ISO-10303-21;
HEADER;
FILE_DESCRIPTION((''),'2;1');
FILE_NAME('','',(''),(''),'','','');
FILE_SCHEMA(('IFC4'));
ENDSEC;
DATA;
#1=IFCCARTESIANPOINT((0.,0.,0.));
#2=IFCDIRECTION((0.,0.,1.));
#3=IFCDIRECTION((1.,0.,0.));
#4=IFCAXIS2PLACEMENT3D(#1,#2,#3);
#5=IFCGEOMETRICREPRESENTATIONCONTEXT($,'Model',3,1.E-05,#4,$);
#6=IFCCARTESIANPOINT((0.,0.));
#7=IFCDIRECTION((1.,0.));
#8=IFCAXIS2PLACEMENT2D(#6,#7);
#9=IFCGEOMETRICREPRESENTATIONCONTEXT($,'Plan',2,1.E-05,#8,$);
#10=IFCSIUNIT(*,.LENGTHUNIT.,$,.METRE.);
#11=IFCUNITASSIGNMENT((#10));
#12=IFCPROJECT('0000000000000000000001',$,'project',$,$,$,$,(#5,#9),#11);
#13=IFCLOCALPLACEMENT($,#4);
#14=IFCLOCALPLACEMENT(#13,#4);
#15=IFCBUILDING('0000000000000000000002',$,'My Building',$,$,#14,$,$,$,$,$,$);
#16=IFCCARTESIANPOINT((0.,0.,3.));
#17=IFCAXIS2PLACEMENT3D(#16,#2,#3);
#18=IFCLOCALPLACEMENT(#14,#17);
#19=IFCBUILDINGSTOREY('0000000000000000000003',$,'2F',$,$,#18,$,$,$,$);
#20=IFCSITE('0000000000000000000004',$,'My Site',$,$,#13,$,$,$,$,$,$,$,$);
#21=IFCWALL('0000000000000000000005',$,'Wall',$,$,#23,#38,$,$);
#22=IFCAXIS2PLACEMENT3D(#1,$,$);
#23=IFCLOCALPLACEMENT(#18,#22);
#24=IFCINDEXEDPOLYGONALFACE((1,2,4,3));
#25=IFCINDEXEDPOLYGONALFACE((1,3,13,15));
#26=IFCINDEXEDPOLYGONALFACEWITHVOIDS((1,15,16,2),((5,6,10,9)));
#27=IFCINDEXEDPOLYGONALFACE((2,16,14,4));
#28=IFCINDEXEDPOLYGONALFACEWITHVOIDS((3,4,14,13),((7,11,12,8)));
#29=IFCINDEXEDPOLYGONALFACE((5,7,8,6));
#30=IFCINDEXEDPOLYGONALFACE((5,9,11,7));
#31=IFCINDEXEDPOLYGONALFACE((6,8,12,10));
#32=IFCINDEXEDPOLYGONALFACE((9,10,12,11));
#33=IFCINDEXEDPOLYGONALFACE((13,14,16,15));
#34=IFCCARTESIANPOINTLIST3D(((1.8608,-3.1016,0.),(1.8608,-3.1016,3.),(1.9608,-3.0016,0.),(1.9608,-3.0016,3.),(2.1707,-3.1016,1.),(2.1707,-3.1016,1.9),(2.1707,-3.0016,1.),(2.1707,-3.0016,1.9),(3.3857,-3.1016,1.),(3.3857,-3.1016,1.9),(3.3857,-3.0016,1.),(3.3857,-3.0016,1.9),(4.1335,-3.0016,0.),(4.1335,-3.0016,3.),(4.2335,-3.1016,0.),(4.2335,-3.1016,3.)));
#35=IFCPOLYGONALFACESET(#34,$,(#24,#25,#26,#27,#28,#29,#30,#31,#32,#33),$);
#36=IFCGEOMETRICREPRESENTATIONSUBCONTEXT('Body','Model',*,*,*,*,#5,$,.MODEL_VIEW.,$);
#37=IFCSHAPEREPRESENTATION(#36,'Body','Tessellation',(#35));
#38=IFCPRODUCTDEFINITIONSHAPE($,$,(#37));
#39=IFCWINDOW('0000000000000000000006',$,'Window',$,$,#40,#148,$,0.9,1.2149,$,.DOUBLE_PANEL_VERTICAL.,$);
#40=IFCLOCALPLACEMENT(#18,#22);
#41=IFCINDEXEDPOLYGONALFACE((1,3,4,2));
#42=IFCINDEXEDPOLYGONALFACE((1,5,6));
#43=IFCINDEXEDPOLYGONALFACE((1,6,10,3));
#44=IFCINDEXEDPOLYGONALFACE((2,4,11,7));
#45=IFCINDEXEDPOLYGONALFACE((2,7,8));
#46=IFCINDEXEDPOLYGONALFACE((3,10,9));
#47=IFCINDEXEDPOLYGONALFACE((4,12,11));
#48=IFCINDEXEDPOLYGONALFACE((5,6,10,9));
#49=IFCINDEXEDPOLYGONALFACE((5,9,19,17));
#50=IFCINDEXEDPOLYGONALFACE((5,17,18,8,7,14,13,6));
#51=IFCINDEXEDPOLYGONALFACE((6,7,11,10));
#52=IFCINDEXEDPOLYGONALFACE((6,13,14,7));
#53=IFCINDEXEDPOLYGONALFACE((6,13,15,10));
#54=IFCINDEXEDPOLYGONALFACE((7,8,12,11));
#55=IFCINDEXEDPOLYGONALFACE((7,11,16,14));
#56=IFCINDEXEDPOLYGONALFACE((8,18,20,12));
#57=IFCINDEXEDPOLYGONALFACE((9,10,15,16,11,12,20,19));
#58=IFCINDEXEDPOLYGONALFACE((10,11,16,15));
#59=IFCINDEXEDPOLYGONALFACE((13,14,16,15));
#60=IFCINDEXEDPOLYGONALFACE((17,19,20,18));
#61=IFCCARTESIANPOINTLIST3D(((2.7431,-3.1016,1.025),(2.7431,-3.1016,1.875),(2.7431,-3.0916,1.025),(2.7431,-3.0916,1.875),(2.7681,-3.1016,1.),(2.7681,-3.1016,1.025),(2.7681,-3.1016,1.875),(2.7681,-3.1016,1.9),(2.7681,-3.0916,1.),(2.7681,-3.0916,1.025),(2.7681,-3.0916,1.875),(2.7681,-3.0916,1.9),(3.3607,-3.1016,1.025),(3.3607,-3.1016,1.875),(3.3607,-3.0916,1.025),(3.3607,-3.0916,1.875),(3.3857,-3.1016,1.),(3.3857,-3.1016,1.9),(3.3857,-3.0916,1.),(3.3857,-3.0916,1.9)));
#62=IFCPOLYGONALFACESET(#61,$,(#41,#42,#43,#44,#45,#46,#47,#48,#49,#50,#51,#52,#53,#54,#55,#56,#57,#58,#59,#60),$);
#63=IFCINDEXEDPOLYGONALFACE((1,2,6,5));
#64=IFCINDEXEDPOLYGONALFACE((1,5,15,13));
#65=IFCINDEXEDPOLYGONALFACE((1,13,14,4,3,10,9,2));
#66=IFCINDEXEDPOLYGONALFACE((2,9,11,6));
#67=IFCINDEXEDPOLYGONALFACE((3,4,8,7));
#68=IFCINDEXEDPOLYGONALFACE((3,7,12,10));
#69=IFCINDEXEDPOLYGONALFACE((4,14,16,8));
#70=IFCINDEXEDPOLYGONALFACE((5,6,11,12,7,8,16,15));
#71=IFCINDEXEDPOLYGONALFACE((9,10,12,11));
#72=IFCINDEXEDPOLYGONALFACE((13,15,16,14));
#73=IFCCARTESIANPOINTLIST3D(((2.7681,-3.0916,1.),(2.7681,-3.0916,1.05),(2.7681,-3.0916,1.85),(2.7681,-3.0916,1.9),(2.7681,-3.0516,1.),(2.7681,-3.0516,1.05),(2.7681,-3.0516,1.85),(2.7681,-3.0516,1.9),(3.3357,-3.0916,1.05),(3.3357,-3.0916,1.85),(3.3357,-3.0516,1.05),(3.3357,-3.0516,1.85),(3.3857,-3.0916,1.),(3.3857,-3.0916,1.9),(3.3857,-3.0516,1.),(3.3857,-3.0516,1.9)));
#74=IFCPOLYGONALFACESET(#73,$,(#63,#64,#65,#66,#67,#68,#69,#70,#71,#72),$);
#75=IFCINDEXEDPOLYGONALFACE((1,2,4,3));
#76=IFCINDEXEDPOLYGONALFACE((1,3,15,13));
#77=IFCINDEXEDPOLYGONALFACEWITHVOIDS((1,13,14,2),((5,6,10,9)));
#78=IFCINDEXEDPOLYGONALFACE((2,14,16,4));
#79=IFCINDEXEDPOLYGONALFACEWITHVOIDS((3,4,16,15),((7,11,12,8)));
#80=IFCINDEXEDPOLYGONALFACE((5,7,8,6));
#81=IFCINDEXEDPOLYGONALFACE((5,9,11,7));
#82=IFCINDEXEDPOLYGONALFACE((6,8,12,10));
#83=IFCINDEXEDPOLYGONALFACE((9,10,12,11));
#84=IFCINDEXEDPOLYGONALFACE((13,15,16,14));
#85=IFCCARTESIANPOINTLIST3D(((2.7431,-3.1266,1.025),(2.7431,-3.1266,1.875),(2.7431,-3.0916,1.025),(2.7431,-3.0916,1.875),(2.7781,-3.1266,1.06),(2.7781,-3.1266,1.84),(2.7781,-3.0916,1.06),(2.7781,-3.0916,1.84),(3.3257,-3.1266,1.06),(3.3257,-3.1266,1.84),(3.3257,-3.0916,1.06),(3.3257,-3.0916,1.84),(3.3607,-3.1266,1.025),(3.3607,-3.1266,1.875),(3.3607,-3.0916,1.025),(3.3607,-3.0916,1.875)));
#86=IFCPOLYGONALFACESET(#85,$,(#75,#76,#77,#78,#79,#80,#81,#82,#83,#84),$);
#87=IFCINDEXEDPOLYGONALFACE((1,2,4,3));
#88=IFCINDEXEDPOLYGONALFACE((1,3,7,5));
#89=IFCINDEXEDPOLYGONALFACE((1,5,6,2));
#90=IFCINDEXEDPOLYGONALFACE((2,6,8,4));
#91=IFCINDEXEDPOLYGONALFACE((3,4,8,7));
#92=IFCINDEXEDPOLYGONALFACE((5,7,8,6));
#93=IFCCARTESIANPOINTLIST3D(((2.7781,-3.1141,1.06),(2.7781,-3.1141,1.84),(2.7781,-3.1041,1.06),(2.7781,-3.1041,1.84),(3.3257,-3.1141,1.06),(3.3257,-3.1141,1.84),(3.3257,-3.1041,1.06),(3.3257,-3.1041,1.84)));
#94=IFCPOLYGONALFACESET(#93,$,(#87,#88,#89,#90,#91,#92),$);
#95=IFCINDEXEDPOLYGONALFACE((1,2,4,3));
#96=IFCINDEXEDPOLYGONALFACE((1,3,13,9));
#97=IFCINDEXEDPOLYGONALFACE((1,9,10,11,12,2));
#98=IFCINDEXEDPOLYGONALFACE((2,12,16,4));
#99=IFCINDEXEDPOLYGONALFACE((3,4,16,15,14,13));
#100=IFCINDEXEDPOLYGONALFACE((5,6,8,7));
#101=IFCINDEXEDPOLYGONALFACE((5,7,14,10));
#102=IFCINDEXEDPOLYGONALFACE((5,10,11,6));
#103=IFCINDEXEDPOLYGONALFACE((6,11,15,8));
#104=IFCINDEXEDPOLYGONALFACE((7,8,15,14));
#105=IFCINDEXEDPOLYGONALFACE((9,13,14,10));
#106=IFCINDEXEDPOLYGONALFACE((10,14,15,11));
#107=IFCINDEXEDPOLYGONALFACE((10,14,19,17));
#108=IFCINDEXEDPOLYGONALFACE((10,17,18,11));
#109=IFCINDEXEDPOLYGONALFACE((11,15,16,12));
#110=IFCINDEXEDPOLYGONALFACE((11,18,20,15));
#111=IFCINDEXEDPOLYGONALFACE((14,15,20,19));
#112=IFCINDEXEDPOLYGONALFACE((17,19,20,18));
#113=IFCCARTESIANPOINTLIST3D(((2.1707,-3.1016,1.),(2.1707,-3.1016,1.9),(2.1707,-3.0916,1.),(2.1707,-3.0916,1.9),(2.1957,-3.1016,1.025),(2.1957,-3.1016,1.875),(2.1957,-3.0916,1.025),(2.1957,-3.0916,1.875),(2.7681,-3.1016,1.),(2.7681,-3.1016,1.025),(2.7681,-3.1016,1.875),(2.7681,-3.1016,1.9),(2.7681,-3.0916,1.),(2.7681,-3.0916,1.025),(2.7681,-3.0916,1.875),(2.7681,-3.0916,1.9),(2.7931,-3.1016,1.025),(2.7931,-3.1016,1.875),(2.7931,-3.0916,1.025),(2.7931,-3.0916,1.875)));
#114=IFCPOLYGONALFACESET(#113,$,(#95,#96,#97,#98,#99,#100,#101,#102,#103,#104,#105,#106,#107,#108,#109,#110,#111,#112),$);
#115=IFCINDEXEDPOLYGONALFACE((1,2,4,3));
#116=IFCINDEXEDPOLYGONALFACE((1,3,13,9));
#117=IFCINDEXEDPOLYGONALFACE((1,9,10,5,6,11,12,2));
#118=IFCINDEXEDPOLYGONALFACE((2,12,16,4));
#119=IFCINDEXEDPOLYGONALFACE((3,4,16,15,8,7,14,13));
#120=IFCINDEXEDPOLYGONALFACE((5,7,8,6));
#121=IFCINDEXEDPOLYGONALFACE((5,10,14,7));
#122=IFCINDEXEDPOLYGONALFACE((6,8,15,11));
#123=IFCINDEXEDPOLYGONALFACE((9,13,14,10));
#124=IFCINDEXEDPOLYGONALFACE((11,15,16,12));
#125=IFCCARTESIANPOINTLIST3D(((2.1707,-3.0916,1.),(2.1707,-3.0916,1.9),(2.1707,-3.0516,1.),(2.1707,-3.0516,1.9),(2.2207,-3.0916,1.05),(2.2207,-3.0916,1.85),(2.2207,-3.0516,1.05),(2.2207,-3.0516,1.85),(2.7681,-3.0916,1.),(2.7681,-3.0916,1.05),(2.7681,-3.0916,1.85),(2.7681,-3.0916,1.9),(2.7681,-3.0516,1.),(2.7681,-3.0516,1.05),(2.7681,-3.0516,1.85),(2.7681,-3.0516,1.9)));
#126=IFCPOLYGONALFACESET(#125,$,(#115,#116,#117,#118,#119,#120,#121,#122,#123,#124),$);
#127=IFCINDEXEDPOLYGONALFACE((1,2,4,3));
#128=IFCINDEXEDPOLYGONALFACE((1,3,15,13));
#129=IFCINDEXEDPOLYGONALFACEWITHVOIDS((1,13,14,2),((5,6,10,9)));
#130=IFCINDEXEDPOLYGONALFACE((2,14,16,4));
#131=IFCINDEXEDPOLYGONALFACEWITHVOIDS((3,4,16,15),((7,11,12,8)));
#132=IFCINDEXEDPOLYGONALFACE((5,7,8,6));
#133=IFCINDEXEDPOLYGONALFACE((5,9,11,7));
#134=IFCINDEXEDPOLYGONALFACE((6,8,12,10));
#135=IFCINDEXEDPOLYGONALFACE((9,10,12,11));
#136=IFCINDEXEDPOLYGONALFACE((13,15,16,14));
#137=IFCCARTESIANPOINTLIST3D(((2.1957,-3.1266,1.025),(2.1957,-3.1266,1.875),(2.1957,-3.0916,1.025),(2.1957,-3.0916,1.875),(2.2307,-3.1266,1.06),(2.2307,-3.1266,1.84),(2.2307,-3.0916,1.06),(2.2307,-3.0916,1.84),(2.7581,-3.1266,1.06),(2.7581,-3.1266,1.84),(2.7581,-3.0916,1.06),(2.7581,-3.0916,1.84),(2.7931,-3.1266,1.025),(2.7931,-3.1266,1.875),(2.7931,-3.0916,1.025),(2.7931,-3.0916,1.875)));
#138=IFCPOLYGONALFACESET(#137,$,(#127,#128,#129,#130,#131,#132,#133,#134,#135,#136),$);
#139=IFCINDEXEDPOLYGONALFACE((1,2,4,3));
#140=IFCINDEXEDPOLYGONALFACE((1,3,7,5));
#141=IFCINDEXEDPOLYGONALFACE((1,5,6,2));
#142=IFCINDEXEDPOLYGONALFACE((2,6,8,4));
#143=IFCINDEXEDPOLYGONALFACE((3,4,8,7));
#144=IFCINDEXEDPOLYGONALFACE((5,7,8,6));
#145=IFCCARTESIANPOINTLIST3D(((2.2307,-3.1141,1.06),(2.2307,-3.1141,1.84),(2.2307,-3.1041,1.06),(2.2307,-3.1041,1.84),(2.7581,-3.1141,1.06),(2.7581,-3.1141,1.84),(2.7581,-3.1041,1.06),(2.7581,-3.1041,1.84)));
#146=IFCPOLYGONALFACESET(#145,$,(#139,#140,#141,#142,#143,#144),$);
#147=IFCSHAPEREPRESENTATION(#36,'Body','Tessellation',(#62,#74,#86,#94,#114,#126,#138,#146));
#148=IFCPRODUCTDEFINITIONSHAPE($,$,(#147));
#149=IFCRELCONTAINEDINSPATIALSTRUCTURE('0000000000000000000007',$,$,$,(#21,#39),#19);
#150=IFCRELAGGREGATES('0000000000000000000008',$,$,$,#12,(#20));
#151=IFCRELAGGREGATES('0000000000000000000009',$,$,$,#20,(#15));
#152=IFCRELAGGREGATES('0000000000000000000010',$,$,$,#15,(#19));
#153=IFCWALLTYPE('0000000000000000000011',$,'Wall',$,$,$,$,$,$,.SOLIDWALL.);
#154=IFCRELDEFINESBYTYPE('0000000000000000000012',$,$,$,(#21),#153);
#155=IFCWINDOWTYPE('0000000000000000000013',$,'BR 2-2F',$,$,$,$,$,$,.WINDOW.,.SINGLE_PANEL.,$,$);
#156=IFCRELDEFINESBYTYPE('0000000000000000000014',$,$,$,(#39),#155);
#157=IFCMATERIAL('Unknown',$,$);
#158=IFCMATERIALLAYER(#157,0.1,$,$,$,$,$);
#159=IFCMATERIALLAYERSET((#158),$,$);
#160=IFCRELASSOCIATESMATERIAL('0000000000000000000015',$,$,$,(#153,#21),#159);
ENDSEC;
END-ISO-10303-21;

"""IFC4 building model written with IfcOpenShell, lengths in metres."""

from ifc_helpers import new_model, entity, si_unit, frame, origin_with_axes, origin_2d_with_axis, place, context, subcontext, project, spatial, line, indexed_curve, outline, extrude, shape, source, transform, mapped, material, layer, layer_set, layer_usage, type_object, type_shapes, element, fill, save


model = new_model("IFC4")

# Units and contexts
model_context = context("Model", 3, precision=1e-05, world=origin_with_axes())
plan_context = context("Plan", 2, precision=1e-05, world=origin_2d_with_axis())
body_context_1 = subcontext(model_context, "Body", "Model", "MODEL_VIEW")
body_context_2 = subcontext(plan_context, "Body", "Plan", "PLAN_VIEW")
ifc_project = project(units=[si_unit("LENGTHUNIT", "METRE")], contexts=[model_context, plan_context])

# Site, building, storey
site_placement = place(None, origin_with_axes())
site = spatial("IfcSite", under=ifc_project, at=site_placement, Name="My Site")
building_placement = place(site_placement, origin_with_axes())
building = spatial("IfcBuilding", under=site, at=building_placement, Name="My Building")
storey_placement = place(building_placement, frame((0.0, 0.0, 3.0), z_axis=(0.0, 0.0, 1.0), x_axis=(1.0, 0.0, 0.0)))
storey = spatial("IfcBuildingStorey", under=building, at=storey_placement, Name="2F")

# Shared definitions
ifc_material = material(Name="Unknown")

# Shared definitions
ifc_layer_1 = layer(ifc_material, 0.1)
ifc_layer_set_1 = layer_set([ifc_layer_1])
wall_type = type_object("IfcWallType", Name="Wall", PredefinedType="SOLIDWALL", material=ifc_layer_set_1)

# Wall, opening, window
ifc_layer_usage_1 = layer_usage(ifc_layer_set_1, "AXIS2", "POSITIVE", 0.0)
wall_1_placement = place(storey_placement, frame((1.8608, -3.1016, 0.0), z_axis=(0.0, 0.0, 1.0), x_axis=(1.0, 0.0, 0.0)))
wall_1 = element("IfcWall", 1, at=wall_1_placement, inside=storey, type_object=wall_type, material=ifc_layer_usage_1, Name="Wall", context=body_context_1, shape_type="SweptSolid", body=[
    extrude(outline(indexed_curve([(0.0, 0.0), (0.1, 0.1), (2.2727, 0.1), (2.3727, 0.0)], segments=[line(1, 2, 3, 4, 1)])), origin_with_axes(), (0.0, 0.0, 1.0), 3.0),
])
shared_shape_1 = source(origin_with_axes(), body_context_1, "Body", "SweptSolid", [
    extrude(outline(indexed_curve([(0.0, 0.0), (1.2149, 0.0), (1.2149, 0.9), (0.0, 0.9)], segments=[line(1, 2, 3, 4, 1)])), frame((0.0, -0.6, 0.0), z_axis=(0.0, -1.0, 0.0), x_axis=(1.0, 0.0, 0.0)), (0.0, 0.0, -1.0), 1.2),
])
opening_1_placement = place(wall_1_placement, frame((1.5248, 0.1, 1.0), z_axis=(0.0, 0.0, 1.0), x_axis=(-1.0, 0.000001, 0.0)))
opening_1 = element("IfcOpeningElement", 2, at=opening_1_placement, cuts=wall_1, PredefinedType="OPENING", context=body_context_1, shape_type="MappedRepresentation", body=[
    mapped(shared_shape_1, transform((0.0, 0.0, 0.0), x_axis=(1.0, 0.0, 0.0), y_axis=(0.0, 1.0, 0.0), z_axis=(0.0, 0.0, 1.0), scale=1.0)),
])
window_type = type_object("IfcWindowType", Name="BR 2-2F", PartitioningType="SINGLE_PANEL", PredefinedType="WINDOW")
shared_shape_2 = source(origin_with_axes(), body_context_1, "Body", "SweptSolid", [
    extrude(outline(indexed_curve([(0.0, 0.0), (0.6176, 0.0), (0.6176, 0.9), (0.0, 0.9)], segments=[line(1, 2, 3, 4, 1)]), holes=[indexed_curve([(0.025, 0.025), (0.6426, 0.025), (0.6426, 0.875), (0.025, 0.875)], segments=[line(1, 2, 3, 4, 1)])]), frame((0.0, 0.09, 0.0), z_axis=(0.0, -1.0, 0.0), x_axis=(1.0, 0.0, 0.0)), (0.0, 0.0, -1.0), 0.01),
    extrude(outline(indexed_curve([(0.6176, 0.0), (0.0, 0.0), (0.0, 0.9), (0.6176, 0.9), (0.6176, 0.85), (0.05, 0.85), (0.05, 0.05), (0.6176, 0.05)], segments=[line(1, 2, 3, 4, 5, 6, 7, 8, 1)])), frame((0.0, 0.05, 0.0), z_axis=(0.0, -1.0, 0.0), x_axis=(1.0, 0.0, 0.0)), (0.0, 0.0, -1.0), 0.04),
    extrude(outline(indexed_curve([(0.0, 0.0), (0.6176, 0.0), (0.6176, 0.85), (0.0, 0.85)], segments=[line(1, 2, 3, 4, 1)]), holes=[indexed_curve([(0.035, 0.035), (0.5826, 0.035), (0.5826, 0.815), (0.035, 0.815)], segments=[line(1, 2, 3, 4, 1)])]), frame((0.025, 0.09, 0.025), z_axis=(0.0, -1.0, 0.0), x_axis=(1.0, 0.0, 0.0)), (0.0, 0.0, -1.0), 0.035),
    extrude(outline(indexed_curve([(0.035, 0.035), (0.5826, 0.035), (0.5826, 0.815), (0.035, 0.815)], segments=[line(1, 2, 3, 4, 1)])), frame((0.025, 0.1025, 0.025), z_axis=(0.0, -1.0, 0.0), x_axis=(1.0, 0.0, 0.0)), (0.0, 0.0, -1.0), 0.01),
    extrude(outline(indexed_curve([(0.0, 0.0), (0.5973, 0.0), (0.5973, 0.9), (0.0, 0.9)], segments=[line(1, 2, 3, 4, 1)]), holes=[indexed_curve([(-0.025, 0.025), (0.5723, 0.025), (0.5723, 0.875), (-0.025, 0.875)], segments=[line(1, 2, 3, 4, 1)])]), frame((0.6176, 0.09, 0.0), z_axis=(0.0, -1.0, 0.0), x_axis=(1.0, 0.0, 0.0)), (0.0, 0.0, -1.0), 0.01),
    extrude(outline(indexed_curve([(0.0, 0.9), (0.5973, 0.9), (0.5973, 0.0), (0.0, 0.0), (0.0, 0.05), (0.5473, 0.05), (0.5473, 0.85), (0.0, 0.85)], segments=[line(1, 2, 3, 4, 5, 6, 7, 8, 1)])), frame((0.6176, 0.05, 0.0), z_axis=(0.0, -1.0, 0.0), x_axis=(1.0, 0.0, 0.0)), (0.0, 0.0, -1.0), 0.04),
    extrude(outline(indexed_curve([(0.0, 0.0), (0.5973, 0.0), (0.5973, 0.85), (0.0, 0.85)], segments=[line(1, 2, 3, 4, 1)]), holes=[indexed_curve([(0.035, 0.035), (0.5623, 0.035), (0.5623, 0.815), (0.035, 0.815)], segments=[line(1, 2, 3, 4, 1)])]), frame((0.5926, 0.09, 0.025), z_axis=(0.0, -1.0, 0.0), x_axis=(1.0, 0.0, 0.0)), (0.0, 0.0, -1.0), 0.035),
    extrude(outline(indexed_curve([(0.035, 0.035), (0.5623, 0.035), (0.5623, 0.815), (0.035, 0.815)], segments=[line(1, 2, 3, 4, 1)])), frame((0.5926, 0.1025, 0.025), z_axis=(0.0, -1.0, 0.0), x_axis=(1.0, 0.0, 0.0)), (0.0, 0.0, -1.0), 0.01),
])
shared_shape_3 = source(origin_with_axes(), body_context_2, "Body", "Curve2D", [
    entity("IfcIndexedPolyCurve", entity("IfcCartesianPointList2D", [[0.05, 0.05], [0.6176, 0.05]])),
    entity("IfcIndexedPolyCurve", entity("IfcCartesianPointList2D", [[0.0, 0.1], [0.025, 0.1], [0.025, 0.09], [0.05, 0.09], [0.05, 0.05], [0.0, 0.05]]), [entity("IfcLineIndex", [1, 2, 3, 4, 5, 6, 1])]),
    entity("IfcIndexedPolyCurve", entity("IfcCartesianPointList2D", [[0.6176, 0.1], [0.6426, 0.1], [0.6426, 0.09], [0.6176, 0.09], [0.6176, 0.05], [0.6176, 0.05]])),
    entity("IfcIndexedPolyCurve", entity("IfcCartesianPointList2D", [[0.025, 0.09], [0.06, 0.09], [0.06, 0.125], [0.025, 0.125]]), [entity("IfcLineIndex", [1, 2, 3, 4, 1])]),
    entity("IfcIndexedPolyCurve", entity("IfcCartesianPointList2D", [[0.6426, 0.09], [0.6076, 0.09], [0.6076, 0.125], [0.6426, 0.125]]), [entity("IfcLineIndex", [1, 2, 3, 4, 1])]),
    entity("IfcIndexedPolyCurve", entity("IfcCartesianPointList2D", [[0.06, 0.09], [0.6076, 0.09]])),
    entity("IfcIndexedPolyCurve", entity("IfcCartesianPointList2D", [[0.06, 0.125], [0.6076, 0.125]])),
    entity("IfcIndexedPolyCurve", entity("IfcCartesianPointList2D", [[0.06, 0.1075], [0.6076, 0.1075]])),
    entity("IfcIndexedPolyCurve", entity("IfcCartesianPointList2D", [[0.6176, 0.05], [1.1649, 0.05]])),
    entity("IfcIndexedPolyCurve", entity("IfcCartesianPointList2D", [[0.6176, 0.1], [0.5926, 0.1], [0.5926, 0.09], [0.6176, 0.09], [0.6176, 0.05], [0.6176, 0.05]])),
    entity("IfcIndexedPolyCurve", entity("IfcCartesianPointList2D", [[1.2149, 0.1], [1.1899, 0.1], [1.1899, 0.09], [1.1649, 0.09], [1.1649, 0.05], [1.2149, 0.05]]), [entity("IfcLineIndex", [1, 2, 3, 4, 5, 6, 1])]),
    entity("IfcIndexedPolyCurve", entity("IfcCartesianPointList2D", [[0.5926, 0.09], [0.6276, 0.09], [0.6276, 0.125], [0.5926, 0.125]]), [entity("IfcLineIndex", [1, 2, 3, 4, 1])]),
    entity("IfcIndexedPolyCurve", entity("IfcCartesianPointList2D", [[1.1899, 0.09], [1.1549, 0.09], [1.1549, 0.125], [1.1899, 0.125]]), [entity("IfcLineIndex", [1, 2, 3, 4, 1])]),
    entity("IfcIndexedPolyCurve", entity("IfcCartesianPointList2D", [[0.6276, 0.09], [1.1549, 0.09]])),
    entity("IfcIndexedPolyCurve", entity("IfcCartesianPointList2D", [[0.6276, 0.125], [1.1549, 0.125]])),
    entity("IfcIndexedPolyCurve", entity("IfcCartesianPointList2D", [[0.6276, 0.1075], [1.1549, 0.1075]])),
])
type_shapes(window_type, [shared_shape_2, shared_shape_3])
window_placement = place(opening_1_placement, origin_with_axes())
window = element("IfcWindow", 3, at=window_placement, inside=storey, type_object=window_type, Name="Window", OverallHeight=0.9, OverallWidth=1.2149, PartitioningType="DOUBLE_PANEL_VERTICAL", shapes=[
    shape(body_context_1, "Body", "MappedRepresentation", [mapped(shared_shape_2, transform((0.0, 0.0, 0.0), x_axis=(1.0, 0.0, 0.0), y_axis=(0.0, 1.0, 0.0), z_axis=(0.0, 0.0, 1.0), scale=1.0))]),
    shape(body_context_2, "Body", "MappedRepresentation", [mapped(shared_shape_3, transform((0.0, 0.0, 0.0), x_axis=(1.0, 0.0, 0.0), y_axis=(0.0, 1.0, 0.0), z_axis=(0.0, 0.0, 1.0), scale=1.0))]),
])
fill(opening_1, window)

save(model, "model.ifc")
